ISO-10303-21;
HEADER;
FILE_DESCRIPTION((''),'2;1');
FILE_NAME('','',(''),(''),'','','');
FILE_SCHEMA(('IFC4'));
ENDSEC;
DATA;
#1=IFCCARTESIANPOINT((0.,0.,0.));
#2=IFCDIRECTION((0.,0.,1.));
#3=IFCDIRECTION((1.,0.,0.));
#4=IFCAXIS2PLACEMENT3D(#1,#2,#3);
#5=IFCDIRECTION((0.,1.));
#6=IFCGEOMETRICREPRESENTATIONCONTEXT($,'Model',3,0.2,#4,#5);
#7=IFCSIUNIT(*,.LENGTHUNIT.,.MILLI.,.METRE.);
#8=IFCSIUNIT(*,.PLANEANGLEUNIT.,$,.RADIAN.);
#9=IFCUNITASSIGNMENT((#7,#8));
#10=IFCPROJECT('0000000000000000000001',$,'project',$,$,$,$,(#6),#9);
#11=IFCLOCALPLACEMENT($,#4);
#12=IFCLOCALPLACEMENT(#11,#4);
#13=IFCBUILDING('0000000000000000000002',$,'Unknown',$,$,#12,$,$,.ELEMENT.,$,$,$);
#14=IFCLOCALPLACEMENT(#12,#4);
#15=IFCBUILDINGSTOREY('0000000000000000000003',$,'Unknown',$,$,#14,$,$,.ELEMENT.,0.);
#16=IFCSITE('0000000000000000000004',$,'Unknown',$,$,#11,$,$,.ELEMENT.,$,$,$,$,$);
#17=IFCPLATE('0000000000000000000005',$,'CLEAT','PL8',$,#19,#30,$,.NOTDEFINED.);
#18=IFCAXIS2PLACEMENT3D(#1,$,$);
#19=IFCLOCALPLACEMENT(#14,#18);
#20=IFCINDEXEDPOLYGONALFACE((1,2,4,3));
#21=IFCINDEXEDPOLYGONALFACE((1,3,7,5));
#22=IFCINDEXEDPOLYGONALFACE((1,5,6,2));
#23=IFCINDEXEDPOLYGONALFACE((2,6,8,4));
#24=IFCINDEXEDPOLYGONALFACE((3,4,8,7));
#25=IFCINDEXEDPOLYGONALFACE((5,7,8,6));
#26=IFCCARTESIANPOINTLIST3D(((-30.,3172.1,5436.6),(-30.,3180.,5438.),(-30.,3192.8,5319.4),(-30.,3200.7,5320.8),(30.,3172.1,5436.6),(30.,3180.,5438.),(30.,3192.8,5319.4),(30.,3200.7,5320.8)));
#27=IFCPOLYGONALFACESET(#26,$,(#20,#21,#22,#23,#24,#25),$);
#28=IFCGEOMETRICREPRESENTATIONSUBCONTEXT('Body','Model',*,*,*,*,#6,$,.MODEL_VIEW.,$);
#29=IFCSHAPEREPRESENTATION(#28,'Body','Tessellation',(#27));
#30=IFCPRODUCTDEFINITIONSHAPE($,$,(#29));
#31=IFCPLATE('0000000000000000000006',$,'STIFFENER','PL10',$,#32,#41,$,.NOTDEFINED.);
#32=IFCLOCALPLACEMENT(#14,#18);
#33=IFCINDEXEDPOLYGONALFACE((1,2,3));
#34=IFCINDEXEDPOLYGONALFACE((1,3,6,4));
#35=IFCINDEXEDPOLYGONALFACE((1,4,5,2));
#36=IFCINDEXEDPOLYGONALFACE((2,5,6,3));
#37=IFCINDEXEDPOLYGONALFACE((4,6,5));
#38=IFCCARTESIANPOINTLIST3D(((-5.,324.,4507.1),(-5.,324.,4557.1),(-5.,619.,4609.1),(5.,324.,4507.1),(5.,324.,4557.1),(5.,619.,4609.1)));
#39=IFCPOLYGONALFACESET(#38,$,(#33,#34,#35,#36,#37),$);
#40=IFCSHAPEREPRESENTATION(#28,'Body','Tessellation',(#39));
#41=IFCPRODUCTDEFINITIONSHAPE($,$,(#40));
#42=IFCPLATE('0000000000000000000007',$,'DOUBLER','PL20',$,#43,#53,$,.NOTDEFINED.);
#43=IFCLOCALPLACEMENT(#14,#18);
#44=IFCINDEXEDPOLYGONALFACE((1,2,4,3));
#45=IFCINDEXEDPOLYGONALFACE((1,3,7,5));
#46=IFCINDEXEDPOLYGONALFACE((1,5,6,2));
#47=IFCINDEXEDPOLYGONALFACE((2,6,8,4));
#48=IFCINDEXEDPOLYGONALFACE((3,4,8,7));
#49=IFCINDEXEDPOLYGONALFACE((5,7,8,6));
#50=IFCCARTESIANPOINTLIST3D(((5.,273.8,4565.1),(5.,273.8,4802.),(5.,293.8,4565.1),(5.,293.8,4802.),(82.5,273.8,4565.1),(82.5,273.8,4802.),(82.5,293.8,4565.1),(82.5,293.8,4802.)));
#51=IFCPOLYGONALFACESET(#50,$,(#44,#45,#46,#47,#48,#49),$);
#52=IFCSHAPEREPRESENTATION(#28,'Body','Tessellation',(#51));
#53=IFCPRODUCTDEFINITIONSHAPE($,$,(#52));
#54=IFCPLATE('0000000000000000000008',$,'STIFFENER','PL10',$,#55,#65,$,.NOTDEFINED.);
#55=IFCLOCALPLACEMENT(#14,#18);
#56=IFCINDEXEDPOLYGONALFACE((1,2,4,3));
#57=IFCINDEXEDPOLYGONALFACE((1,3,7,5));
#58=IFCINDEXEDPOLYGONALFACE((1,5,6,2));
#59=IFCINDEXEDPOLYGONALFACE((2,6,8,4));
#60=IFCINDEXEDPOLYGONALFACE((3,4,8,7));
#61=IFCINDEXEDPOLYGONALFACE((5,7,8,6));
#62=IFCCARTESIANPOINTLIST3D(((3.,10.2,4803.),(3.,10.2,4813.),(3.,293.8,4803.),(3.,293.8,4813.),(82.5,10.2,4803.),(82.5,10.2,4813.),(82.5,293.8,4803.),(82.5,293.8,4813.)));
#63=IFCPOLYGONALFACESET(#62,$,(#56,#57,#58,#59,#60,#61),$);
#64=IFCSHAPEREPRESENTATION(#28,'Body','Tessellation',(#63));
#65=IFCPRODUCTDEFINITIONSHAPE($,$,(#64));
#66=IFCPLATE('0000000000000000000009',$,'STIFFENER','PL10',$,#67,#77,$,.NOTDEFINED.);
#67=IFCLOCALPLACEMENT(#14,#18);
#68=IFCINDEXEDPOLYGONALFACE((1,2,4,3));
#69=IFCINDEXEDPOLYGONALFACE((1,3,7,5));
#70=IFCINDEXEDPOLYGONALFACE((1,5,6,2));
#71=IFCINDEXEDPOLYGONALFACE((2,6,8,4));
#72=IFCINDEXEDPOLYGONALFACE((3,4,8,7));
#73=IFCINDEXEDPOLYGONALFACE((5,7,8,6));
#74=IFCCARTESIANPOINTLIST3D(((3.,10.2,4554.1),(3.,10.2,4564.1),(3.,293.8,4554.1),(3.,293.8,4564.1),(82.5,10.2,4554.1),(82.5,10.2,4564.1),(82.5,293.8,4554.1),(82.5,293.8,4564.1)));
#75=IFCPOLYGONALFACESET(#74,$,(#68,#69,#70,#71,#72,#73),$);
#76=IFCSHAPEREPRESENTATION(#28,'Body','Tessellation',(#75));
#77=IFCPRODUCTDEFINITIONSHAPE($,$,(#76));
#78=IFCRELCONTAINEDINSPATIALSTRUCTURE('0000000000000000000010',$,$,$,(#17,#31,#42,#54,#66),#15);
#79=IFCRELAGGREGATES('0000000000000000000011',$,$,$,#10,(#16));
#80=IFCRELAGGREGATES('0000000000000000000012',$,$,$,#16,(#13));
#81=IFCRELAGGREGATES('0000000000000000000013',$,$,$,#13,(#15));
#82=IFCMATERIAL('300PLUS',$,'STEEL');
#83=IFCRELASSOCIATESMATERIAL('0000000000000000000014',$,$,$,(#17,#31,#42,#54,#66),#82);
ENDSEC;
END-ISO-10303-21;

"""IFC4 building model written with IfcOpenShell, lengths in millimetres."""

from ifc_helpers import new_model, si_unit, direction, frame, origin_with_axes, place, context, subcontext, project, spatial, line, indexed_curve, outline, extrude, material, element, save


model = new_model("IFC4")

# Units and contexts
model_context = context("Model", 3, precision=0.2, world=origin_with_axes(), true_north=direction((0.0, 1.0)))
body_context = subcontext(model_context, "Body", "Model", "MODEL_VIEW")
ifc_project = project(units=[si_unit("LENGTHUNIT", "METRE", prefix="MILLI"), si_unit("PLANEANGLEUNIT", "RADIAN")], contexts=[model_context])

# Site, building, storey
site_placement = place(None, origin_with_axes())
site = spatial("IfcSite", under=ifc_project, at=site_placement, Name="Unknown", CompositionType="ELEMENT")
building_placement = place(site_placement, origin_with_axes())
building = spatial("IfcBuilding", under=site, at=building_placement, Name="Unknown", CompositionType="ELEMENT")
storey_placement = place(building_placement, origin_with_axes())
storey = spatial("IfcBuildingStorey", under=building, at=storey_placement, Name="Unknown", CompositionType="ELEMENT", Elevation=0.0)

# Shared definitions
ifc_material_1 = material(Name="300PLUS", Category="STEEL")

# Plates
for number, where, z_axis, x_axis, name in (
    (1, (30.0, 3196.7, 5320.1), (0.0, 0.984758, 0.173929), (-1.0, 0.0, 0.0), "CLEAT"),
):
    element("IfcPlate", number, at=place(storey_placement, frame(where, z_axis=z_axis, x_axis=x_axis)), inside=storey, material=ifc_material_1, Name=name, Description="PL8", PredefinedType="NOTDEFINED", context=body_context, shape_type="SolidModel", body=[
        extrude(outline(indexed_curve([(0.0, 0.0), (60.0, 0.0), (60.0, 119.0), (0.0, 119.0)], segments=[line(1, 2, 3, 4, 1)])), frame((0.0, 0.0, 4.0), z_axis=(0.0, 0.0, 1.0), x_axis=(1.0, 0.0, 0.0)), (0.0, 0.0, -1.0), 8.0),
    ])
plate_1_placement = place(storey_placement, frame((0.0, 619.0, 4609.1), z_axis=(1.0, 0.0, 0.0), x_axis=(0.0, -0.984817, -0.173595)))
element("IfcPlate", 2, at=plate_1_placement, inside=storey, material=ifc_material_1, Name="STIFFENER", Description="PL10", PredefinedType="NOTDEFINED", context=body_context, shape_type="SolidModel", body=[
    extrude(outline(indexed_curve([(0.0, 0.0), (299.5, 0.0), (308.2, 49.2)], segments=[line(1, 2, 3, 1)])), frame((0.0, 0.0, 5.0), z_axis=(0.0, 0.0, 1.0), x_axis=(1.0, 0.0, 0.0)), (0.0, 0.0, -1.0), 10.0),
])
plate_2_placement = place(storey_placement, frame((5.0, 283.8, 4565.1), z_axis=(0.0, -1.0, 0.0), x_axis=(1.0, 0.0, 0.0)))
element("IfcPlate", 3, at=plate_2_placement, inside=storey, material=ifc_material_1, Name="DOUBLER", Description="PL20", PredefinedType="NOTDEFINED", context=body_context, shape_type="SolidModel", body=[
    extrude(outline(indexed_curve([(0.0, 0.0), (77.5, 0.0), (77.5, 236.9), (0.0, 236.9)], segments=[line(1, 2, 3, 4, 1)])), frame((0.0, 0.0, 10.0), z_axis=(0.0, 0.0, 1.0), x_axis=(1.0, 0.0, 0.0)), (0.0, 0.0, -1.0), 20.0),
])
for number, where, z_axis, x_axis, name in (
    (4, (3.0, 10.2, 4808.0), (0.0, 0.0, 1.0), (1.0, 0.0, 0.0), "STIFFENER"),
    (5, (3.0, 10.2, 4559.1), (0.0, 0.0, 1.0), (1.0, 0.0, 0.0), "STIFFENER"),
):
    element("IfcPlate", number, at=place(storey_placement, frame(where, z_axis=z_axis, x_axis=x_axis)), inside=storey, material=ifc_material_1, Name=name, Description="PL10", PredefinedType="NOTDEFINED", context=body_context, shape_type="SolidModel", body=[
        extrude(outline(indexed_curve([(0.0, 0.0), (79.5, 0.0), (79.5, 283.6), (0.0, 283.6)], segments=[line(1, 2, 3, 4, 1)])), frame((0.0, 0.0, 5.0), z_axis=(0.0, 0.0, 1.0), x_axis=(1.0, 0.0, 0.0)), (0.0, 0.0, -1.0), 10.0),
    ])

save(model, "model.ifc")
